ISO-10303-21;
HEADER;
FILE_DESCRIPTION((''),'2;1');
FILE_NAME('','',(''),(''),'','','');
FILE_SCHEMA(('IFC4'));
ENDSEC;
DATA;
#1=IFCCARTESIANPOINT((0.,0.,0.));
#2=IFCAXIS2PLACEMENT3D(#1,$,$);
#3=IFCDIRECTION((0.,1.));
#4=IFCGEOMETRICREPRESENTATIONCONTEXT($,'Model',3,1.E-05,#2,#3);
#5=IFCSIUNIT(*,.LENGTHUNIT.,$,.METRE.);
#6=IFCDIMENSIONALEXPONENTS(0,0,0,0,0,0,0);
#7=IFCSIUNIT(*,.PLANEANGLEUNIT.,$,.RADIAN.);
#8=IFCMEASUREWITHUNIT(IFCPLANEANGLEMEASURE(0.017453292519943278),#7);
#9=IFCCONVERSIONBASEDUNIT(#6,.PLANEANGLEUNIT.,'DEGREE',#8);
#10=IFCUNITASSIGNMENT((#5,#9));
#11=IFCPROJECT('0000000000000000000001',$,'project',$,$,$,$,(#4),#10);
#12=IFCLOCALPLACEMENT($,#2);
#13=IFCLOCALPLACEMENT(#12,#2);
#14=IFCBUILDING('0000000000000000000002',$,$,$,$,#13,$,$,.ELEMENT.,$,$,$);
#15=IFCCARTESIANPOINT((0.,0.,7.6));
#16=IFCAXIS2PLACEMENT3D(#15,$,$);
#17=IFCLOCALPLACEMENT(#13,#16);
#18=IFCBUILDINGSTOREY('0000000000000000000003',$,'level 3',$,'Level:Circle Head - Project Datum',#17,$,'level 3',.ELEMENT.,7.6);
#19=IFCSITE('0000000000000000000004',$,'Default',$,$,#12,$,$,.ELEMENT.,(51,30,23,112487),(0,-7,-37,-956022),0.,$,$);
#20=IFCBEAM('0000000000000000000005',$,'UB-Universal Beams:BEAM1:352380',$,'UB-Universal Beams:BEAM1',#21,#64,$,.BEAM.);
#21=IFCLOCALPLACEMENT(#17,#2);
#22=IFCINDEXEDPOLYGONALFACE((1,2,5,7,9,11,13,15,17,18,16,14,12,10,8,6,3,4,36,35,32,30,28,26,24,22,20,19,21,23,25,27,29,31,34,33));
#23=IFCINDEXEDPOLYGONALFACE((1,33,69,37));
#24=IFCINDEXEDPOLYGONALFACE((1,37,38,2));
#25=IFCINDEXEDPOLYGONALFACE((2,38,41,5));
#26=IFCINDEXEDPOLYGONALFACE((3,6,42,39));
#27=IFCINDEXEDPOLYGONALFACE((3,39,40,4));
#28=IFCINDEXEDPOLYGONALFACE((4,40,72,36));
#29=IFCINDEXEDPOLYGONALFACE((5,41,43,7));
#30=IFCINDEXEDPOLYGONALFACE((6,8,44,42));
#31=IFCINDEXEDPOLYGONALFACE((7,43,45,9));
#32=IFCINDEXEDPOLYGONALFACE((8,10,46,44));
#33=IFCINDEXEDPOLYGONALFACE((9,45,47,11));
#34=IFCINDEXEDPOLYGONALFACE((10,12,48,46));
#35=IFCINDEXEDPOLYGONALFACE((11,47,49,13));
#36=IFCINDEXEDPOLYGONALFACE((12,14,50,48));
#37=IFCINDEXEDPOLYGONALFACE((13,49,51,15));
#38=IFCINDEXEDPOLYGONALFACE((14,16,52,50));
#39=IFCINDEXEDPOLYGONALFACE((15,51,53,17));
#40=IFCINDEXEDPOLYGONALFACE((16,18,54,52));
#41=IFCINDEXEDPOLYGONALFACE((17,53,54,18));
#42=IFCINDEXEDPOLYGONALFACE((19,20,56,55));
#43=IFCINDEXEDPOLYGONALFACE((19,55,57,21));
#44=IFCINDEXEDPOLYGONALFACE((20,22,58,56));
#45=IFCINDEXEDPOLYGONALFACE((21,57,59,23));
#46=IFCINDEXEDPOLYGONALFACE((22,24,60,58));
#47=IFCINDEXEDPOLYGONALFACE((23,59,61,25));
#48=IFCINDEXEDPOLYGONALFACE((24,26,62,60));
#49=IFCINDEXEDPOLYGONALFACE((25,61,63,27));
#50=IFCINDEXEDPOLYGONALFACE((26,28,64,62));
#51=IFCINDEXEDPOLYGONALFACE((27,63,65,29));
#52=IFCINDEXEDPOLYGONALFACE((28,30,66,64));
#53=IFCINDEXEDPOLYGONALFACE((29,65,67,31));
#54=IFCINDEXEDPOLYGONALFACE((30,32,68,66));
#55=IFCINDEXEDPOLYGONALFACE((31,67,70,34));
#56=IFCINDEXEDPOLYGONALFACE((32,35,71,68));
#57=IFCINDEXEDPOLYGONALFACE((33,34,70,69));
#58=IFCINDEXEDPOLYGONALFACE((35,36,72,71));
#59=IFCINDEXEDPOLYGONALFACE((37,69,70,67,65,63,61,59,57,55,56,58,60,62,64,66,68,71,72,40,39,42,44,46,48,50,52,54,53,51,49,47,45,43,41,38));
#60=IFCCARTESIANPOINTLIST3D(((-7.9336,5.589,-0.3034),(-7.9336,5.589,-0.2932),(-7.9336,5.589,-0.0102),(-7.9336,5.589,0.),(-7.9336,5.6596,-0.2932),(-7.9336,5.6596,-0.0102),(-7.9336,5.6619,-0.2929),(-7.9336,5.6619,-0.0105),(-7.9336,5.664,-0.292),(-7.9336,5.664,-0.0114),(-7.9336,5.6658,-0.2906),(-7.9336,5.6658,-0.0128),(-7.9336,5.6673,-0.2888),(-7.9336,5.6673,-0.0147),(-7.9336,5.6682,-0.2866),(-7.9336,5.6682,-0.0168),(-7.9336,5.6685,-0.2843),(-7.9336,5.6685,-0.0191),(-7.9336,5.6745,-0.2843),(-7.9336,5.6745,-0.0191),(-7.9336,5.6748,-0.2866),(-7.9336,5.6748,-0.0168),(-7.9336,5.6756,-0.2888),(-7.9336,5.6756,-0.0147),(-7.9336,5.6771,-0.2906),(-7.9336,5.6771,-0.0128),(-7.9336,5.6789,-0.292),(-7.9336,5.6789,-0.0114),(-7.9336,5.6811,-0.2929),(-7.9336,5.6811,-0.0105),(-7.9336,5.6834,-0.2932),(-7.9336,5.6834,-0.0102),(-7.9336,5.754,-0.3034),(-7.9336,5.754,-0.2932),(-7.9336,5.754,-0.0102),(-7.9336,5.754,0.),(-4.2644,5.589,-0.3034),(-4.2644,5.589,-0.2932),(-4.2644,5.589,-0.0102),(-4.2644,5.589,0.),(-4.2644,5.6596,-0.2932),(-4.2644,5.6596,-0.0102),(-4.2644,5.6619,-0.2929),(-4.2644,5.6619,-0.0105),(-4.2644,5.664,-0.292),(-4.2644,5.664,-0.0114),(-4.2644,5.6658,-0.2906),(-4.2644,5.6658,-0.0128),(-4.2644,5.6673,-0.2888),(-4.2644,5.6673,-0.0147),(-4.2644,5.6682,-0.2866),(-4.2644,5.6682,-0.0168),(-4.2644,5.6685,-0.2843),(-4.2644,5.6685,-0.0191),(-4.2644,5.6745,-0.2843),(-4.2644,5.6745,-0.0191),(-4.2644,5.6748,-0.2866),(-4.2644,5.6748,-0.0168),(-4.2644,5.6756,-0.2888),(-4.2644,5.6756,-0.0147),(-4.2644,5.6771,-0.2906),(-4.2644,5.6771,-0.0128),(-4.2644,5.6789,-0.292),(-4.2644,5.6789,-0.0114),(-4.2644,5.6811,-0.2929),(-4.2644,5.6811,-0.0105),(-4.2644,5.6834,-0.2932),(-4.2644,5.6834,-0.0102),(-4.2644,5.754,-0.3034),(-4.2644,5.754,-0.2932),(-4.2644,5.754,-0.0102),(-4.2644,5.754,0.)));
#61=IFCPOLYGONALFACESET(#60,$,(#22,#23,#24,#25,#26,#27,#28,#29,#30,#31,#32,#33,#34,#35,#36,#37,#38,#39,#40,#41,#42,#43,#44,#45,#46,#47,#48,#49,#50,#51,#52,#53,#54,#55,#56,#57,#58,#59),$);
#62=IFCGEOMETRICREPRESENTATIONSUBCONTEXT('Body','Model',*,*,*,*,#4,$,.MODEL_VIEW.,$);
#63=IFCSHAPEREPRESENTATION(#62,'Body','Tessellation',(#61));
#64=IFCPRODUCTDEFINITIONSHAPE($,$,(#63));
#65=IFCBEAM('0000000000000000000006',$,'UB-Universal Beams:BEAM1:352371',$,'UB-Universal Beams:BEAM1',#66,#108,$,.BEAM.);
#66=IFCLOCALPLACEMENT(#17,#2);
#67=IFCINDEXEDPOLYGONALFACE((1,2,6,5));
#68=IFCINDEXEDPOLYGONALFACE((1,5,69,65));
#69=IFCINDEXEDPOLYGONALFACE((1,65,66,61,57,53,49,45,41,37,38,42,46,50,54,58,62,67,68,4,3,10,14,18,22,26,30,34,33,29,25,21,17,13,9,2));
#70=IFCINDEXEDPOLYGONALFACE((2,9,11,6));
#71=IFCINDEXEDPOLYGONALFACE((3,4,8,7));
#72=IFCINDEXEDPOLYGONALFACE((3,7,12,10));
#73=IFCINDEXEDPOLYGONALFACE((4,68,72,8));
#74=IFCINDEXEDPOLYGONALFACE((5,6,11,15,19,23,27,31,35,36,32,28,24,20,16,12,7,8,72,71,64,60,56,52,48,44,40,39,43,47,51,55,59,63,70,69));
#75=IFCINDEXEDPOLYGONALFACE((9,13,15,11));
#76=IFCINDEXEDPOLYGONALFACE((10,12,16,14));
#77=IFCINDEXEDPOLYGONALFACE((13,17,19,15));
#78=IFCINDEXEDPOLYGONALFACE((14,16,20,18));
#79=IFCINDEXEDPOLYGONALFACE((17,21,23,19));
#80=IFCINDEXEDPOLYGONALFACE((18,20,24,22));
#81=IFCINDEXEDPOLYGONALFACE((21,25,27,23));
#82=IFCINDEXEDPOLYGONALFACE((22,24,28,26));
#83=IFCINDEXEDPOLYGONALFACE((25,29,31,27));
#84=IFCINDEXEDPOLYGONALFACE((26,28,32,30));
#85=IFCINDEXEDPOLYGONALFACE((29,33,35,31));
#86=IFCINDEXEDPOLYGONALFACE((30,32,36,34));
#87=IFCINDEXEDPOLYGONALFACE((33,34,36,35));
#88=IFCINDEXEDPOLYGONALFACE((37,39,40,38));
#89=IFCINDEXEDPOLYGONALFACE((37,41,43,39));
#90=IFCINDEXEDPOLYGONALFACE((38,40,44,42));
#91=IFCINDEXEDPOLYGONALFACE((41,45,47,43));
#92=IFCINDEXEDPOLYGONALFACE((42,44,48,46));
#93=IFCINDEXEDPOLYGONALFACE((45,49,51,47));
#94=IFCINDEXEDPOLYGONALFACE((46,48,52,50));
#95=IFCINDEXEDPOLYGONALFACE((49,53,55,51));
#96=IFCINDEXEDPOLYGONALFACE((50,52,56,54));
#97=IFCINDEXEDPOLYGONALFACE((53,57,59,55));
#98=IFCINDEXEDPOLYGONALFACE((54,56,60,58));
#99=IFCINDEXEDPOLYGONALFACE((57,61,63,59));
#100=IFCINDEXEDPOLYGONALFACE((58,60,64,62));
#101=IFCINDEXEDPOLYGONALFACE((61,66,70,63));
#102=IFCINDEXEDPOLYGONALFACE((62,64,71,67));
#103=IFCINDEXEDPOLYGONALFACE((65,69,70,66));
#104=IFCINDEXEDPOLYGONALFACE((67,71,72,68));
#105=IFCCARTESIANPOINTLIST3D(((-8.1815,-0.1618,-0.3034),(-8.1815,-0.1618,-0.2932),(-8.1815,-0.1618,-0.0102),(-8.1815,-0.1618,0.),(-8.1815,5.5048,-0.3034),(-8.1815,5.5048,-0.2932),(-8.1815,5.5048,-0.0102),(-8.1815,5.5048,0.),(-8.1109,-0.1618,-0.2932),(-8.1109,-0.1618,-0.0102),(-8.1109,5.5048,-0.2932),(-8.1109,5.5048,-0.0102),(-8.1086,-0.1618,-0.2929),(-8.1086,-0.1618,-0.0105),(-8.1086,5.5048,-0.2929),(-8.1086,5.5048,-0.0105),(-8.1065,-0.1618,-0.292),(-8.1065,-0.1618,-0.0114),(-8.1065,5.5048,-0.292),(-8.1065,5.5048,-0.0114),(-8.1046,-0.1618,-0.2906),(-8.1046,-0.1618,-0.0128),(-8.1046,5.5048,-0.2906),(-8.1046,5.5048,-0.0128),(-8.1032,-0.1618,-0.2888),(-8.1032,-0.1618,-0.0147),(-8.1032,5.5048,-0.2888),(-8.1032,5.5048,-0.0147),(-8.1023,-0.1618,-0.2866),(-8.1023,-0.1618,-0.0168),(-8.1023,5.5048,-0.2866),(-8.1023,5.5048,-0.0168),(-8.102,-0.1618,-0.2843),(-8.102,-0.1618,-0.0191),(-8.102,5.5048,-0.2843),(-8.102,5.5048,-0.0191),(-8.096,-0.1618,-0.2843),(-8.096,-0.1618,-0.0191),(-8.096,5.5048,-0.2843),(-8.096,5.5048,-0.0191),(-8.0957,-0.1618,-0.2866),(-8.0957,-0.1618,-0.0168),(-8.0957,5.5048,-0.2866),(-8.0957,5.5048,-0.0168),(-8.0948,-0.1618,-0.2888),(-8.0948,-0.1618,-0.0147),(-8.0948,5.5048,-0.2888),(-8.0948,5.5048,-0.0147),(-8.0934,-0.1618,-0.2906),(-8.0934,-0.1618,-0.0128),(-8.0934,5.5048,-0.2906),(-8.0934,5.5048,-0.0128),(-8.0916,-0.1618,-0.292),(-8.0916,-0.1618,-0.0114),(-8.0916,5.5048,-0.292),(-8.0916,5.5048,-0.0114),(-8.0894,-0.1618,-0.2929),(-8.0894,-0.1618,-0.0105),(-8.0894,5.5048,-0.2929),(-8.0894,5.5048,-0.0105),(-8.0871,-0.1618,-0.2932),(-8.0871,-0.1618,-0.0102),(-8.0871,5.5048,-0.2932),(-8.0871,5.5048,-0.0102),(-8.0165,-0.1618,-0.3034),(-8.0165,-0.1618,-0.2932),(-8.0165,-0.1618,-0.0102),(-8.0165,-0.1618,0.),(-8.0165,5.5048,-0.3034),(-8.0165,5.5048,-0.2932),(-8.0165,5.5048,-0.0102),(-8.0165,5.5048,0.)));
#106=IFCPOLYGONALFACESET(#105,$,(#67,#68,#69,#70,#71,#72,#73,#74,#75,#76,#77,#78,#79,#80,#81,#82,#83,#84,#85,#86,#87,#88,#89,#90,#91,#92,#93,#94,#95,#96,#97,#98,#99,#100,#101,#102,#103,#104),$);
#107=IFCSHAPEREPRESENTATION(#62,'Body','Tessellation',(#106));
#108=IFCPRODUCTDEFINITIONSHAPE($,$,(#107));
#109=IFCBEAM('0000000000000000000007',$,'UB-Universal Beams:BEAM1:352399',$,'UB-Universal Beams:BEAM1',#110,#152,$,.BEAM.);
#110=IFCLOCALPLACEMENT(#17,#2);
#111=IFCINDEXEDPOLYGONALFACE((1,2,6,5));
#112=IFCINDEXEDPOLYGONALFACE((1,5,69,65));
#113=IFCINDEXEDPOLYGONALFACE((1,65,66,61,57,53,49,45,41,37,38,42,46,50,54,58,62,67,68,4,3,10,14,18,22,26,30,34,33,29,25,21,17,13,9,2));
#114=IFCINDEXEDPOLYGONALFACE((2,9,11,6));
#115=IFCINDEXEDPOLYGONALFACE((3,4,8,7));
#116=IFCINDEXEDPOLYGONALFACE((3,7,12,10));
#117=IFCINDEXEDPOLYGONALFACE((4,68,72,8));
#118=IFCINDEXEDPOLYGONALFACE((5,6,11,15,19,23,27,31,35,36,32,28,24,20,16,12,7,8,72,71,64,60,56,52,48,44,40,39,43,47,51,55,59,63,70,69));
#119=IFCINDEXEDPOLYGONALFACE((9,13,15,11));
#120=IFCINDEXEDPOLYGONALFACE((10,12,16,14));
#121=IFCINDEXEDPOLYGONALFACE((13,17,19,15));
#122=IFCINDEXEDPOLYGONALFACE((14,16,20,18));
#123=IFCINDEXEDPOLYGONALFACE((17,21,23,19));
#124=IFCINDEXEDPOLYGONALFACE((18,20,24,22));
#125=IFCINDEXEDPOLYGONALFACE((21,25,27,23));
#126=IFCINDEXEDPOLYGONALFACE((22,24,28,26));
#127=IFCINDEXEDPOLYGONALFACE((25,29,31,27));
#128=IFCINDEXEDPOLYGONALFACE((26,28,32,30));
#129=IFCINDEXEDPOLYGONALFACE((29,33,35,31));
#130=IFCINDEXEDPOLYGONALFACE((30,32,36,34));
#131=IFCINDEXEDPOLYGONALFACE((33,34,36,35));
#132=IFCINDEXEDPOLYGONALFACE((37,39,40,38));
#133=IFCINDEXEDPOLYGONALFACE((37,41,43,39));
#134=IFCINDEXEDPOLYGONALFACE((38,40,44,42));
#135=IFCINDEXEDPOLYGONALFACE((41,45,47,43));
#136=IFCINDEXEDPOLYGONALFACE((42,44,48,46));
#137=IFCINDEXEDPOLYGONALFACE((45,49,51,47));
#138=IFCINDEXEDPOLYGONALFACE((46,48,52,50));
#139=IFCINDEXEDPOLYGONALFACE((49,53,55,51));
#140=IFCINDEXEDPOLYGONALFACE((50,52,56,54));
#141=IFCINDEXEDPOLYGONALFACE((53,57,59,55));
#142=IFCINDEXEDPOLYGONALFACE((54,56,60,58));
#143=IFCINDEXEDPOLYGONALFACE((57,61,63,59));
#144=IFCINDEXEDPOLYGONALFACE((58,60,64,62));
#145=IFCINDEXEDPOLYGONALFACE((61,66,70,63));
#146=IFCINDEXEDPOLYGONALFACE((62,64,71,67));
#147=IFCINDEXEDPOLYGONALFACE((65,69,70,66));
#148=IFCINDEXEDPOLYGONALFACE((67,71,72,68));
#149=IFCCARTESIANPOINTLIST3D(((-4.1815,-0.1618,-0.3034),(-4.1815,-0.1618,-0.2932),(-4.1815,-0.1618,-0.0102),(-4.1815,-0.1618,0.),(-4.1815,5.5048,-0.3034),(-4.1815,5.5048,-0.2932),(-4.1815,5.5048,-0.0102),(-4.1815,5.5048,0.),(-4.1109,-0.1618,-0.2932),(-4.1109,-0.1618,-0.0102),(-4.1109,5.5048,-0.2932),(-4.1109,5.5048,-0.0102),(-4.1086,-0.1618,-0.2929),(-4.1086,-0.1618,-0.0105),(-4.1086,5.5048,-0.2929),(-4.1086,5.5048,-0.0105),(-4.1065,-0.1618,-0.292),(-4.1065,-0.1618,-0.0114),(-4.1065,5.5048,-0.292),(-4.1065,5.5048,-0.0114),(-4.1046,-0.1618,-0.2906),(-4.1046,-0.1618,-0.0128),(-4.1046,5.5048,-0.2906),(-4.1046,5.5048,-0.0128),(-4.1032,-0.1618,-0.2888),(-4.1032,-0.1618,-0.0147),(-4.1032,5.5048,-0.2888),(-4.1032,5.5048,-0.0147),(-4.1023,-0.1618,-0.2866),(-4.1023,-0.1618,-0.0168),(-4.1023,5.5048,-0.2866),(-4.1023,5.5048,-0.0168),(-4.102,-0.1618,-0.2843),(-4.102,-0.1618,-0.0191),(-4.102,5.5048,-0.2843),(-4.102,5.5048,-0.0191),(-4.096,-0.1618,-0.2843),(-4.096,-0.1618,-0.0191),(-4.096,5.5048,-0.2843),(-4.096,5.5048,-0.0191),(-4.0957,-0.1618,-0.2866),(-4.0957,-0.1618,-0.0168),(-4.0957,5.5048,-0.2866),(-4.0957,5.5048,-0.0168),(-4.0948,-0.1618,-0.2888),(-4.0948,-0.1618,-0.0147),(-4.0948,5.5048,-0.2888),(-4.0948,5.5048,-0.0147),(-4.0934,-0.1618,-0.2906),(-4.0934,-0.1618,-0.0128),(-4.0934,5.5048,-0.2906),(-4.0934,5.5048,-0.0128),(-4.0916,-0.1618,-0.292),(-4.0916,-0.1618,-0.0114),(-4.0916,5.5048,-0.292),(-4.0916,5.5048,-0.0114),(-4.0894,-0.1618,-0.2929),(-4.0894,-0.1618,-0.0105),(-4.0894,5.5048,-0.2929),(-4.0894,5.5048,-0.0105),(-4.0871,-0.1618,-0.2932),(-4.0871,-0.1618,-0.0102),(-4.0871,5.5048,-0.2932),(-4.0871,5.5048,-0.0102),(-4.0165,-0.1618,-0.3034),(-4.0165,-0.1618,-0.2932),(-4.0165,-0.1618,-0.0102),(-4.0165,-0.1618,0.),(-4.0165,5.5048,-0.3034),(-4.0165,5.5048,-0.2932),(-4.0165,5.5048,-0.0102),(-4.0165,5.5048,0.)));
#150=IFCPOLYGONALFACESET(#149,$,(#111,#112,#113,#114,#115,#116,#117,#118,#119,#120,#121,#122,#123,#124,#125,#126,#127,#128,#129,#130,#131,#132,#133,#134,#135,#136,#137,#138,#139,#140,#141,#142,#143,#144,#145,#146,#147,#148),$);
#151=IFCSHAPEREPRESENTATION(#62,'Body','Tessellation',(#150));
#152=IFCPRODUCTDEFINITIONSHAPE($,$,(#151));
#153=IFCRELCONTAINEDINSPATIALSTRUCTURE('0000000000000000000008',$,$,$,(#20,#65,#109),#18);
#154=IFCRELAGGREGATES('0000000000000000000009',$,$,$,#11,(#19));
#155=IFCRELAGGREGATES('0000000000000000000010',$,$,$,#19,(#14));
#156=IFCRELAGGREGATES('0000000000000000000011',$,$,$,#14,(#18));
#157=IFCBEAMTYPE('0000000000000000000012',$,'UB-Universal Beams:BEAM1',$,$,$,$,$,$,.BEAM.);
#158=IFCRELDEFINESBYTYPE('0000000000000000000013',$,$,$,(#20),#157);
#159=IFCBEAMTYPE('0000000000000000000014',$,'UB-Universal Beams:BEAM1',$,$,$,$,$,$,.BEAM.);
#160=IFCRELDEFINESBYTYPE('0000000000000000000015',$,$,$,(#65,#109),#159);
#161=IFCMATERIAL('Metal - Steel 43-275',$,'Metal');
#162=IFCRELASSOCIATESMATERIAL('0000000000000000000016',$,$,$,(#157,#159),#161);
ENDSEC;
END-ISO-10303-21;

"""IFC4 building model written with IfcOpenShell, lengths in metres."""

from ifc_helpers import new_model, entity, si_unit, converted_unit, direction, frame, frame_2d, origin, place, context, subcontext, project, spatial, polyline, circle_curve, parameter, trimmed, segment, composite_curve, outline, extrude, source, transform, mapped, material, material_profile, profile_set, type_object, type_shapes, element, save


model = new_model("IFC4")

# Units and contexts
model_context = context("Model", 3, precision=1e-05, world=origin(), true_north=direction((0.0, 1.0)))
body_context = subcontext(model_context, "Body", "Model", "MODEL_VIEW")
ifc_project = project(units=[si_unit("LENGTHUNIT", "METRE"), converted_unit("PLANEANGLEUNIT", "DEGREE", entity("IfcPlaneAngleMeasure", 0.017453292519943278), si_unit("PLANEANGLEUNIT", "RADIAN"), dimensions=[0, 0, 0, 0, 0, 0, 0])], contexts=[model_context])

# Site, building, storey
site_placement = place(None, origin())
site = spatial("IfcSite", under=ifc_project, at=site_placement, Name="Default", CompositionType="ELEMENT", RefLatitude=(51, 30, 23, 112487), RefLongitude=(0, -7, -37, -956022), RefElevation=0.0)
building_placement = place(site_placement, origin())
building = spatial("IfcBuilding", under=site, at=building_placement, CompositionType="ELEMENT")
storey_placement = place(building_placement, frame((0.0, 0.0, 7.6)))
storey = spatial("IfcBuildingStorey", under=building, at=storey_placement, Name="level 3", ObjectType="Level:Circle Head - Project Datum", LongName="level 3", CompositionType="ELEMENT", Elevation=7.6)

# Shared definitions
ifc_material_1 = material(Name="Metal - Steel 43-275", Category="Metal")

# Beams
ifc_material_profile_1 = material_profile(ifc_material_1, outline(composite_curve([segment(polyline([(-0.0825, -0.1415), (-0.0825, -0.1517)]), True, "CONTINUOUS"), segment(polyline([(-0.0825, -0.1517), (0.0825, -0.1517)]), True, "CONTINUOUS"), segment(polyline([(0.0825, -0.1517), (0.0825, -0.1415)]), True, "CONTINUOUS"), segment(polyline([(0.0825, -0.1415), (0.0119, -0.1415)]), True, "CONTINUOUS"), segment(trimmed(circle_curve(frame_2d((0.0119, -0.1326), x_axis=(1.0, 0.0)), 0.0089), [parameter(180.0)], [parameter(270.0)], True, "PARAMETER"), False, "CONTINUOUS"), segment(polyline([(0.003, -0.1326), (0.003, 0.1326)]), True, "CONTINUOUS"), segment(trimmed(circle_curve(frame_2d((0.0119, 0.1326), x_axis=(1.0, 0.0)), 0.0089), [parameter(90.0)], [parameter(180.0)], True, "PARAMETER"), False, "CONTINUOUS"), segment(polyline([(0.0119, 0.1415), (0.0825, 0.1415)]), True, "CONTINUOUS"), segment(polyline([(0.0825, 0.1415), (0.0825, 0.1517)]), True, "CONTINUOUS"), segment(polyline([(0.0825, 0.1517), (-0.0825, 0.1517)]), True, "CONTINUOUS"), segment(polyline([(-0.0825, 0.1517), (-0.0825, 0.1415)]), True, "CONTINUOUS"), segment(polyline([(-0.0825, 0.1415), (-0.0119, 0.1415)]), True, "CONTINUOUS"), segment(trimmed(circle_curve(frame_2d((-0.0119, 0.1326), x_axis=(1.0, 0.0)), 0.0089), [parameter(360.0)], [parameter(90.0)], True, "PARAMETER"), False, "CONTINUOUS"), segment(polyline([(-0.003, 0.1326), (-0.003, -0.1326)]), True, "CONTINUOUS"), segment(trimmed(circle_curve(frame_2d((-0.0119, -0.1326), x_axis=(1.0, 0.0)), 0.0089), [parameter(270.0)], [parameter(360.0)], True, "PARAMETER"), False, "CONTINUOUS"), segment(polyline([(-0.0119, -0.1415), (-0.0825, -0.1415)]), True, "CONTINUOUS")], self_intersect=False)), Name="BEAM1")
ifc_profile_set_1 = profile_set([ifc_material_profile_1], Name="BEAM1")
beam_type_1 = type_object("IfcBeamType", Name="UB-Universal Beams:BEAM1", PredefinedType="BEAM", material=ifc_profile_set_1)
shared_shape_1 = source(origin(), body_context, "Body", "SweptSolid", [
    extrude(outline(composite_curve([segment(polyline([(-0.0825, -0.1415), (-0.0825, -0.1517)]), True, "CONTINUOUS"), segment(polyline([(-0.0825, -0.1517), (0.0825, -0.1517)]), True, "CONTINUOUS"), segment(polyline([(0.0825, -0.1517), (0.0825, -0.1415)]), True, "CONTINUOUS"), segment(polyline([(0.0825, -0.1415), (0.0119, -0.1415)]), True, "CONTINUOUS"), segment(trimmed(circle_curve(frame_2d((0.0119, -0.1326), x_axis=(0.0, -1.0)), 0.0089), [parameter(270.0)], [parameter(360.0)], True, "PARAMETER"), False, "CONTINUOUS"), segment(polyline([(0.003, -0.1326), (0.003, 0.1326)]), True, "CONTINUOUS"), segment(trimmed(circle_curve(frame_2d((0.0119, 0.1326), x_axis=(-1.0, 0.0)), 0.0089), [parameter(270.0)], [parameter(360.0)], True, "PARAMETER"), False, "CONTINUOUS"), segment(polyline([(0.0119, 0.1415), (0.0825, 0.1415)]), True, "CONTINUOUS"), segment(polyline([(0.0825, 0.1415), (0.0825, 0.1517)]), True, "CONTINUOUS"), segment(polyline([(0.0825, 0.1517), (-0.0825, 0.1517)]), True, "CONTINUOUS"), segment(polyline([(-0.0825, 0.1517), (-0.0825, 0.1415)]), True, "CONTINUOUS"), segment(polyline([(-0.0825, 0.1415), (-0.0119, 0.1415)]), True, "CONTINUOUS"), segment(trimmed(circle_curve(frame_2d((-0.0119, 0.1326), x_axis=(0.0, 1.0)), 0.0089), [parameter(270.0)], [parameter(360.0)], True, "PARAMETER"), False, "CONTINUOUS"), segment(polyline([(-0.003, 0.1326), (-0.003, -0.1326)]), True, "CONTINUOUS"), segment(trimmed(circle_curve(frame_2d((-0.0119, -0.1326), x_axis=(1.0, 0.0)), 0.0089), [parameter(270.0)], [parameter(0.0)], True, "PARAMETER"), False, "CONTINUOUS"), segment(polyline([(-0.0119, -0.1415), (-0.0825, -0.1415)]), True, "CONTINUOUS")], self_intersect=False)), frame((-1.8346, 0.0, 0.0), z_axis=(-1.0, 0.0, 0.0), x_axis=(0.0, -1.0, 0.0)), (0.0, 0.0, -1.0), 3.6692),
])
type_shapes(beam_type_1, [shared_shape_1])
beam_1_placement = place(storey_placement, frame((-6.099, 5.6715, -0.1517)))
element("IfcBeam", 1, at=beam_1_placement, inside=storey, type_object=beam_type_1, Name="UB-Universal Beams:BEAM1:352380", ObjectType="UB-Universal Beams:BEAM1", PredefinedType="BEAM", context=body_context, shape_type="MappedRepresentation", body=[
    mapped(shared_shape_1, transform((0.0, 0.0, 0.0), scale=1.0)),
])
beam_type_2 = type_object("IfcBeamType", Name="UB-Universal Beams:BEAM1", PredefinedType="BEAM", material=ifc_profile_set_1)
shared_shape_2 = source(origin(), body_context, "Body", "SweptSolid", [
    extrude(outline(composite_curve([segment(polyline([(-0.0825, -0.1415), (-0.0825, -0.1517)]), True, "CONTINUOUS"), segment(polyline([(-0.0825, -0.1517), (0.0825, -0.1517)]), True, "CONTINUOUS"), segment(polyline([(0.0825, -0.1517), (0.0825, -0.1415)]), True, "CONTINUOUS"), segment(polyline([(0.0825, -0.1415), (0.0119, -0.1415)]), True, "CONTINUOUS"), segment(trimmed(circle_curve(frame_2d((0.0119, -0.1326), x_axis=(1.0, 0.0)), 0.0089), [parameter(180.0)], [parameter(270.0)], True, "PARAMETER"), False, "CONTINUOUS"), segment(polyline([(0.003, -0.1326), (0.003, 0.1326)]), True, "CONTINUOUS"), segment(trimmed(circle_curve(frame_2d((0.0119, 0.1326), x_axis=(1.0, 0.0)), 0.0089), [parameter(90.0)], [parameter(180.0)], True, "PARAMETER"), False, "CONTINUOUS"), segment(polyline([(0.0119, 0.1415), (0.0825, 0.1415)]), True, "CONTINUOUS"), segment(polyline([(0.0825, 0.1415), (0.0825, 0.1517)]), True, "CONTINUOUS"), segment(polyline([(0.0825, 0.1517), (-0.0825, 0.1517)]), True, "CONTINUOUS"), segment(polyline([(-0.0825, 0.1517), (-0.0825, 0.1415)]), True, "CONTINUOUS"), segment(polyline([(-0.0825, 0.1415), (-0.0119, 0.1415)]), True, "CONTINUOUS"), segment(trimmed(circle_curve(frame_2d((-0.0119, 0.1326), x_axis=(1.0, 0.0)), 0.0089), [parameter(360.0)], [parameter(90.0)], True, "PARAMETER"), False, "CONTINUOUS"), segment(polyline([(-0.003, 0.1326), (-0.003, -0.1326)]), True, "CONTINUOUS"), segment(trimmed(circle_curve(frame_2d((-0.0119, -0.1326), x_axis=(1.0, 0.0)), 0.0089), [parameter(270.0)], [parameter(360.0)], True, "PARAMETER"), False, "CONTINUOUS"), segment(polyline([(-0.0119, -0.1415), (-0.0825, -0.1415)]), True, "CONTINUOUS")], self_intersect=False)), frame((-2.8333, 0.0, 0.0), z_axis=(-1.0, 0.0, 0.0), x_axis=(0.0, -1.0, 0.0)), (0.0, 0.0, -1.0), 5.6666),
])
type_shapes(beam_type_2, [shared_shape_2])
for number, where, z_axis, x_axis, name in (
    (2, (-8.099, 2.6715, -0.1517), (0.0, 0.0, 1.0), (0.0, -1.0, 0.0), "UB-Universal Beams:BEAM1:352371"),
    (3, (-4.099, 2.6715, -0.1517), (0.0, 0.0, 1.0), (0.0, -1.0, 0.0), "UB-Universal Beams:BEAM1:352399"),
):
    element("IfcBeam", number, at=place(storey_placement, frame(where, z_axis=z_axis, x_axis=x_axis)), inside=storey, type_object=beam_type_2, Name=name, ObjectType="UB-Universal Beams:BEAM1", PredefinedType="BEAM", context=body_context, shape_type="MappedRepresentation", body=[
        mapped(shared_shape_2, transform((0.0, 0.0, 0.0), scale=1.0)),
    ])

save(model, "model.ifc")
